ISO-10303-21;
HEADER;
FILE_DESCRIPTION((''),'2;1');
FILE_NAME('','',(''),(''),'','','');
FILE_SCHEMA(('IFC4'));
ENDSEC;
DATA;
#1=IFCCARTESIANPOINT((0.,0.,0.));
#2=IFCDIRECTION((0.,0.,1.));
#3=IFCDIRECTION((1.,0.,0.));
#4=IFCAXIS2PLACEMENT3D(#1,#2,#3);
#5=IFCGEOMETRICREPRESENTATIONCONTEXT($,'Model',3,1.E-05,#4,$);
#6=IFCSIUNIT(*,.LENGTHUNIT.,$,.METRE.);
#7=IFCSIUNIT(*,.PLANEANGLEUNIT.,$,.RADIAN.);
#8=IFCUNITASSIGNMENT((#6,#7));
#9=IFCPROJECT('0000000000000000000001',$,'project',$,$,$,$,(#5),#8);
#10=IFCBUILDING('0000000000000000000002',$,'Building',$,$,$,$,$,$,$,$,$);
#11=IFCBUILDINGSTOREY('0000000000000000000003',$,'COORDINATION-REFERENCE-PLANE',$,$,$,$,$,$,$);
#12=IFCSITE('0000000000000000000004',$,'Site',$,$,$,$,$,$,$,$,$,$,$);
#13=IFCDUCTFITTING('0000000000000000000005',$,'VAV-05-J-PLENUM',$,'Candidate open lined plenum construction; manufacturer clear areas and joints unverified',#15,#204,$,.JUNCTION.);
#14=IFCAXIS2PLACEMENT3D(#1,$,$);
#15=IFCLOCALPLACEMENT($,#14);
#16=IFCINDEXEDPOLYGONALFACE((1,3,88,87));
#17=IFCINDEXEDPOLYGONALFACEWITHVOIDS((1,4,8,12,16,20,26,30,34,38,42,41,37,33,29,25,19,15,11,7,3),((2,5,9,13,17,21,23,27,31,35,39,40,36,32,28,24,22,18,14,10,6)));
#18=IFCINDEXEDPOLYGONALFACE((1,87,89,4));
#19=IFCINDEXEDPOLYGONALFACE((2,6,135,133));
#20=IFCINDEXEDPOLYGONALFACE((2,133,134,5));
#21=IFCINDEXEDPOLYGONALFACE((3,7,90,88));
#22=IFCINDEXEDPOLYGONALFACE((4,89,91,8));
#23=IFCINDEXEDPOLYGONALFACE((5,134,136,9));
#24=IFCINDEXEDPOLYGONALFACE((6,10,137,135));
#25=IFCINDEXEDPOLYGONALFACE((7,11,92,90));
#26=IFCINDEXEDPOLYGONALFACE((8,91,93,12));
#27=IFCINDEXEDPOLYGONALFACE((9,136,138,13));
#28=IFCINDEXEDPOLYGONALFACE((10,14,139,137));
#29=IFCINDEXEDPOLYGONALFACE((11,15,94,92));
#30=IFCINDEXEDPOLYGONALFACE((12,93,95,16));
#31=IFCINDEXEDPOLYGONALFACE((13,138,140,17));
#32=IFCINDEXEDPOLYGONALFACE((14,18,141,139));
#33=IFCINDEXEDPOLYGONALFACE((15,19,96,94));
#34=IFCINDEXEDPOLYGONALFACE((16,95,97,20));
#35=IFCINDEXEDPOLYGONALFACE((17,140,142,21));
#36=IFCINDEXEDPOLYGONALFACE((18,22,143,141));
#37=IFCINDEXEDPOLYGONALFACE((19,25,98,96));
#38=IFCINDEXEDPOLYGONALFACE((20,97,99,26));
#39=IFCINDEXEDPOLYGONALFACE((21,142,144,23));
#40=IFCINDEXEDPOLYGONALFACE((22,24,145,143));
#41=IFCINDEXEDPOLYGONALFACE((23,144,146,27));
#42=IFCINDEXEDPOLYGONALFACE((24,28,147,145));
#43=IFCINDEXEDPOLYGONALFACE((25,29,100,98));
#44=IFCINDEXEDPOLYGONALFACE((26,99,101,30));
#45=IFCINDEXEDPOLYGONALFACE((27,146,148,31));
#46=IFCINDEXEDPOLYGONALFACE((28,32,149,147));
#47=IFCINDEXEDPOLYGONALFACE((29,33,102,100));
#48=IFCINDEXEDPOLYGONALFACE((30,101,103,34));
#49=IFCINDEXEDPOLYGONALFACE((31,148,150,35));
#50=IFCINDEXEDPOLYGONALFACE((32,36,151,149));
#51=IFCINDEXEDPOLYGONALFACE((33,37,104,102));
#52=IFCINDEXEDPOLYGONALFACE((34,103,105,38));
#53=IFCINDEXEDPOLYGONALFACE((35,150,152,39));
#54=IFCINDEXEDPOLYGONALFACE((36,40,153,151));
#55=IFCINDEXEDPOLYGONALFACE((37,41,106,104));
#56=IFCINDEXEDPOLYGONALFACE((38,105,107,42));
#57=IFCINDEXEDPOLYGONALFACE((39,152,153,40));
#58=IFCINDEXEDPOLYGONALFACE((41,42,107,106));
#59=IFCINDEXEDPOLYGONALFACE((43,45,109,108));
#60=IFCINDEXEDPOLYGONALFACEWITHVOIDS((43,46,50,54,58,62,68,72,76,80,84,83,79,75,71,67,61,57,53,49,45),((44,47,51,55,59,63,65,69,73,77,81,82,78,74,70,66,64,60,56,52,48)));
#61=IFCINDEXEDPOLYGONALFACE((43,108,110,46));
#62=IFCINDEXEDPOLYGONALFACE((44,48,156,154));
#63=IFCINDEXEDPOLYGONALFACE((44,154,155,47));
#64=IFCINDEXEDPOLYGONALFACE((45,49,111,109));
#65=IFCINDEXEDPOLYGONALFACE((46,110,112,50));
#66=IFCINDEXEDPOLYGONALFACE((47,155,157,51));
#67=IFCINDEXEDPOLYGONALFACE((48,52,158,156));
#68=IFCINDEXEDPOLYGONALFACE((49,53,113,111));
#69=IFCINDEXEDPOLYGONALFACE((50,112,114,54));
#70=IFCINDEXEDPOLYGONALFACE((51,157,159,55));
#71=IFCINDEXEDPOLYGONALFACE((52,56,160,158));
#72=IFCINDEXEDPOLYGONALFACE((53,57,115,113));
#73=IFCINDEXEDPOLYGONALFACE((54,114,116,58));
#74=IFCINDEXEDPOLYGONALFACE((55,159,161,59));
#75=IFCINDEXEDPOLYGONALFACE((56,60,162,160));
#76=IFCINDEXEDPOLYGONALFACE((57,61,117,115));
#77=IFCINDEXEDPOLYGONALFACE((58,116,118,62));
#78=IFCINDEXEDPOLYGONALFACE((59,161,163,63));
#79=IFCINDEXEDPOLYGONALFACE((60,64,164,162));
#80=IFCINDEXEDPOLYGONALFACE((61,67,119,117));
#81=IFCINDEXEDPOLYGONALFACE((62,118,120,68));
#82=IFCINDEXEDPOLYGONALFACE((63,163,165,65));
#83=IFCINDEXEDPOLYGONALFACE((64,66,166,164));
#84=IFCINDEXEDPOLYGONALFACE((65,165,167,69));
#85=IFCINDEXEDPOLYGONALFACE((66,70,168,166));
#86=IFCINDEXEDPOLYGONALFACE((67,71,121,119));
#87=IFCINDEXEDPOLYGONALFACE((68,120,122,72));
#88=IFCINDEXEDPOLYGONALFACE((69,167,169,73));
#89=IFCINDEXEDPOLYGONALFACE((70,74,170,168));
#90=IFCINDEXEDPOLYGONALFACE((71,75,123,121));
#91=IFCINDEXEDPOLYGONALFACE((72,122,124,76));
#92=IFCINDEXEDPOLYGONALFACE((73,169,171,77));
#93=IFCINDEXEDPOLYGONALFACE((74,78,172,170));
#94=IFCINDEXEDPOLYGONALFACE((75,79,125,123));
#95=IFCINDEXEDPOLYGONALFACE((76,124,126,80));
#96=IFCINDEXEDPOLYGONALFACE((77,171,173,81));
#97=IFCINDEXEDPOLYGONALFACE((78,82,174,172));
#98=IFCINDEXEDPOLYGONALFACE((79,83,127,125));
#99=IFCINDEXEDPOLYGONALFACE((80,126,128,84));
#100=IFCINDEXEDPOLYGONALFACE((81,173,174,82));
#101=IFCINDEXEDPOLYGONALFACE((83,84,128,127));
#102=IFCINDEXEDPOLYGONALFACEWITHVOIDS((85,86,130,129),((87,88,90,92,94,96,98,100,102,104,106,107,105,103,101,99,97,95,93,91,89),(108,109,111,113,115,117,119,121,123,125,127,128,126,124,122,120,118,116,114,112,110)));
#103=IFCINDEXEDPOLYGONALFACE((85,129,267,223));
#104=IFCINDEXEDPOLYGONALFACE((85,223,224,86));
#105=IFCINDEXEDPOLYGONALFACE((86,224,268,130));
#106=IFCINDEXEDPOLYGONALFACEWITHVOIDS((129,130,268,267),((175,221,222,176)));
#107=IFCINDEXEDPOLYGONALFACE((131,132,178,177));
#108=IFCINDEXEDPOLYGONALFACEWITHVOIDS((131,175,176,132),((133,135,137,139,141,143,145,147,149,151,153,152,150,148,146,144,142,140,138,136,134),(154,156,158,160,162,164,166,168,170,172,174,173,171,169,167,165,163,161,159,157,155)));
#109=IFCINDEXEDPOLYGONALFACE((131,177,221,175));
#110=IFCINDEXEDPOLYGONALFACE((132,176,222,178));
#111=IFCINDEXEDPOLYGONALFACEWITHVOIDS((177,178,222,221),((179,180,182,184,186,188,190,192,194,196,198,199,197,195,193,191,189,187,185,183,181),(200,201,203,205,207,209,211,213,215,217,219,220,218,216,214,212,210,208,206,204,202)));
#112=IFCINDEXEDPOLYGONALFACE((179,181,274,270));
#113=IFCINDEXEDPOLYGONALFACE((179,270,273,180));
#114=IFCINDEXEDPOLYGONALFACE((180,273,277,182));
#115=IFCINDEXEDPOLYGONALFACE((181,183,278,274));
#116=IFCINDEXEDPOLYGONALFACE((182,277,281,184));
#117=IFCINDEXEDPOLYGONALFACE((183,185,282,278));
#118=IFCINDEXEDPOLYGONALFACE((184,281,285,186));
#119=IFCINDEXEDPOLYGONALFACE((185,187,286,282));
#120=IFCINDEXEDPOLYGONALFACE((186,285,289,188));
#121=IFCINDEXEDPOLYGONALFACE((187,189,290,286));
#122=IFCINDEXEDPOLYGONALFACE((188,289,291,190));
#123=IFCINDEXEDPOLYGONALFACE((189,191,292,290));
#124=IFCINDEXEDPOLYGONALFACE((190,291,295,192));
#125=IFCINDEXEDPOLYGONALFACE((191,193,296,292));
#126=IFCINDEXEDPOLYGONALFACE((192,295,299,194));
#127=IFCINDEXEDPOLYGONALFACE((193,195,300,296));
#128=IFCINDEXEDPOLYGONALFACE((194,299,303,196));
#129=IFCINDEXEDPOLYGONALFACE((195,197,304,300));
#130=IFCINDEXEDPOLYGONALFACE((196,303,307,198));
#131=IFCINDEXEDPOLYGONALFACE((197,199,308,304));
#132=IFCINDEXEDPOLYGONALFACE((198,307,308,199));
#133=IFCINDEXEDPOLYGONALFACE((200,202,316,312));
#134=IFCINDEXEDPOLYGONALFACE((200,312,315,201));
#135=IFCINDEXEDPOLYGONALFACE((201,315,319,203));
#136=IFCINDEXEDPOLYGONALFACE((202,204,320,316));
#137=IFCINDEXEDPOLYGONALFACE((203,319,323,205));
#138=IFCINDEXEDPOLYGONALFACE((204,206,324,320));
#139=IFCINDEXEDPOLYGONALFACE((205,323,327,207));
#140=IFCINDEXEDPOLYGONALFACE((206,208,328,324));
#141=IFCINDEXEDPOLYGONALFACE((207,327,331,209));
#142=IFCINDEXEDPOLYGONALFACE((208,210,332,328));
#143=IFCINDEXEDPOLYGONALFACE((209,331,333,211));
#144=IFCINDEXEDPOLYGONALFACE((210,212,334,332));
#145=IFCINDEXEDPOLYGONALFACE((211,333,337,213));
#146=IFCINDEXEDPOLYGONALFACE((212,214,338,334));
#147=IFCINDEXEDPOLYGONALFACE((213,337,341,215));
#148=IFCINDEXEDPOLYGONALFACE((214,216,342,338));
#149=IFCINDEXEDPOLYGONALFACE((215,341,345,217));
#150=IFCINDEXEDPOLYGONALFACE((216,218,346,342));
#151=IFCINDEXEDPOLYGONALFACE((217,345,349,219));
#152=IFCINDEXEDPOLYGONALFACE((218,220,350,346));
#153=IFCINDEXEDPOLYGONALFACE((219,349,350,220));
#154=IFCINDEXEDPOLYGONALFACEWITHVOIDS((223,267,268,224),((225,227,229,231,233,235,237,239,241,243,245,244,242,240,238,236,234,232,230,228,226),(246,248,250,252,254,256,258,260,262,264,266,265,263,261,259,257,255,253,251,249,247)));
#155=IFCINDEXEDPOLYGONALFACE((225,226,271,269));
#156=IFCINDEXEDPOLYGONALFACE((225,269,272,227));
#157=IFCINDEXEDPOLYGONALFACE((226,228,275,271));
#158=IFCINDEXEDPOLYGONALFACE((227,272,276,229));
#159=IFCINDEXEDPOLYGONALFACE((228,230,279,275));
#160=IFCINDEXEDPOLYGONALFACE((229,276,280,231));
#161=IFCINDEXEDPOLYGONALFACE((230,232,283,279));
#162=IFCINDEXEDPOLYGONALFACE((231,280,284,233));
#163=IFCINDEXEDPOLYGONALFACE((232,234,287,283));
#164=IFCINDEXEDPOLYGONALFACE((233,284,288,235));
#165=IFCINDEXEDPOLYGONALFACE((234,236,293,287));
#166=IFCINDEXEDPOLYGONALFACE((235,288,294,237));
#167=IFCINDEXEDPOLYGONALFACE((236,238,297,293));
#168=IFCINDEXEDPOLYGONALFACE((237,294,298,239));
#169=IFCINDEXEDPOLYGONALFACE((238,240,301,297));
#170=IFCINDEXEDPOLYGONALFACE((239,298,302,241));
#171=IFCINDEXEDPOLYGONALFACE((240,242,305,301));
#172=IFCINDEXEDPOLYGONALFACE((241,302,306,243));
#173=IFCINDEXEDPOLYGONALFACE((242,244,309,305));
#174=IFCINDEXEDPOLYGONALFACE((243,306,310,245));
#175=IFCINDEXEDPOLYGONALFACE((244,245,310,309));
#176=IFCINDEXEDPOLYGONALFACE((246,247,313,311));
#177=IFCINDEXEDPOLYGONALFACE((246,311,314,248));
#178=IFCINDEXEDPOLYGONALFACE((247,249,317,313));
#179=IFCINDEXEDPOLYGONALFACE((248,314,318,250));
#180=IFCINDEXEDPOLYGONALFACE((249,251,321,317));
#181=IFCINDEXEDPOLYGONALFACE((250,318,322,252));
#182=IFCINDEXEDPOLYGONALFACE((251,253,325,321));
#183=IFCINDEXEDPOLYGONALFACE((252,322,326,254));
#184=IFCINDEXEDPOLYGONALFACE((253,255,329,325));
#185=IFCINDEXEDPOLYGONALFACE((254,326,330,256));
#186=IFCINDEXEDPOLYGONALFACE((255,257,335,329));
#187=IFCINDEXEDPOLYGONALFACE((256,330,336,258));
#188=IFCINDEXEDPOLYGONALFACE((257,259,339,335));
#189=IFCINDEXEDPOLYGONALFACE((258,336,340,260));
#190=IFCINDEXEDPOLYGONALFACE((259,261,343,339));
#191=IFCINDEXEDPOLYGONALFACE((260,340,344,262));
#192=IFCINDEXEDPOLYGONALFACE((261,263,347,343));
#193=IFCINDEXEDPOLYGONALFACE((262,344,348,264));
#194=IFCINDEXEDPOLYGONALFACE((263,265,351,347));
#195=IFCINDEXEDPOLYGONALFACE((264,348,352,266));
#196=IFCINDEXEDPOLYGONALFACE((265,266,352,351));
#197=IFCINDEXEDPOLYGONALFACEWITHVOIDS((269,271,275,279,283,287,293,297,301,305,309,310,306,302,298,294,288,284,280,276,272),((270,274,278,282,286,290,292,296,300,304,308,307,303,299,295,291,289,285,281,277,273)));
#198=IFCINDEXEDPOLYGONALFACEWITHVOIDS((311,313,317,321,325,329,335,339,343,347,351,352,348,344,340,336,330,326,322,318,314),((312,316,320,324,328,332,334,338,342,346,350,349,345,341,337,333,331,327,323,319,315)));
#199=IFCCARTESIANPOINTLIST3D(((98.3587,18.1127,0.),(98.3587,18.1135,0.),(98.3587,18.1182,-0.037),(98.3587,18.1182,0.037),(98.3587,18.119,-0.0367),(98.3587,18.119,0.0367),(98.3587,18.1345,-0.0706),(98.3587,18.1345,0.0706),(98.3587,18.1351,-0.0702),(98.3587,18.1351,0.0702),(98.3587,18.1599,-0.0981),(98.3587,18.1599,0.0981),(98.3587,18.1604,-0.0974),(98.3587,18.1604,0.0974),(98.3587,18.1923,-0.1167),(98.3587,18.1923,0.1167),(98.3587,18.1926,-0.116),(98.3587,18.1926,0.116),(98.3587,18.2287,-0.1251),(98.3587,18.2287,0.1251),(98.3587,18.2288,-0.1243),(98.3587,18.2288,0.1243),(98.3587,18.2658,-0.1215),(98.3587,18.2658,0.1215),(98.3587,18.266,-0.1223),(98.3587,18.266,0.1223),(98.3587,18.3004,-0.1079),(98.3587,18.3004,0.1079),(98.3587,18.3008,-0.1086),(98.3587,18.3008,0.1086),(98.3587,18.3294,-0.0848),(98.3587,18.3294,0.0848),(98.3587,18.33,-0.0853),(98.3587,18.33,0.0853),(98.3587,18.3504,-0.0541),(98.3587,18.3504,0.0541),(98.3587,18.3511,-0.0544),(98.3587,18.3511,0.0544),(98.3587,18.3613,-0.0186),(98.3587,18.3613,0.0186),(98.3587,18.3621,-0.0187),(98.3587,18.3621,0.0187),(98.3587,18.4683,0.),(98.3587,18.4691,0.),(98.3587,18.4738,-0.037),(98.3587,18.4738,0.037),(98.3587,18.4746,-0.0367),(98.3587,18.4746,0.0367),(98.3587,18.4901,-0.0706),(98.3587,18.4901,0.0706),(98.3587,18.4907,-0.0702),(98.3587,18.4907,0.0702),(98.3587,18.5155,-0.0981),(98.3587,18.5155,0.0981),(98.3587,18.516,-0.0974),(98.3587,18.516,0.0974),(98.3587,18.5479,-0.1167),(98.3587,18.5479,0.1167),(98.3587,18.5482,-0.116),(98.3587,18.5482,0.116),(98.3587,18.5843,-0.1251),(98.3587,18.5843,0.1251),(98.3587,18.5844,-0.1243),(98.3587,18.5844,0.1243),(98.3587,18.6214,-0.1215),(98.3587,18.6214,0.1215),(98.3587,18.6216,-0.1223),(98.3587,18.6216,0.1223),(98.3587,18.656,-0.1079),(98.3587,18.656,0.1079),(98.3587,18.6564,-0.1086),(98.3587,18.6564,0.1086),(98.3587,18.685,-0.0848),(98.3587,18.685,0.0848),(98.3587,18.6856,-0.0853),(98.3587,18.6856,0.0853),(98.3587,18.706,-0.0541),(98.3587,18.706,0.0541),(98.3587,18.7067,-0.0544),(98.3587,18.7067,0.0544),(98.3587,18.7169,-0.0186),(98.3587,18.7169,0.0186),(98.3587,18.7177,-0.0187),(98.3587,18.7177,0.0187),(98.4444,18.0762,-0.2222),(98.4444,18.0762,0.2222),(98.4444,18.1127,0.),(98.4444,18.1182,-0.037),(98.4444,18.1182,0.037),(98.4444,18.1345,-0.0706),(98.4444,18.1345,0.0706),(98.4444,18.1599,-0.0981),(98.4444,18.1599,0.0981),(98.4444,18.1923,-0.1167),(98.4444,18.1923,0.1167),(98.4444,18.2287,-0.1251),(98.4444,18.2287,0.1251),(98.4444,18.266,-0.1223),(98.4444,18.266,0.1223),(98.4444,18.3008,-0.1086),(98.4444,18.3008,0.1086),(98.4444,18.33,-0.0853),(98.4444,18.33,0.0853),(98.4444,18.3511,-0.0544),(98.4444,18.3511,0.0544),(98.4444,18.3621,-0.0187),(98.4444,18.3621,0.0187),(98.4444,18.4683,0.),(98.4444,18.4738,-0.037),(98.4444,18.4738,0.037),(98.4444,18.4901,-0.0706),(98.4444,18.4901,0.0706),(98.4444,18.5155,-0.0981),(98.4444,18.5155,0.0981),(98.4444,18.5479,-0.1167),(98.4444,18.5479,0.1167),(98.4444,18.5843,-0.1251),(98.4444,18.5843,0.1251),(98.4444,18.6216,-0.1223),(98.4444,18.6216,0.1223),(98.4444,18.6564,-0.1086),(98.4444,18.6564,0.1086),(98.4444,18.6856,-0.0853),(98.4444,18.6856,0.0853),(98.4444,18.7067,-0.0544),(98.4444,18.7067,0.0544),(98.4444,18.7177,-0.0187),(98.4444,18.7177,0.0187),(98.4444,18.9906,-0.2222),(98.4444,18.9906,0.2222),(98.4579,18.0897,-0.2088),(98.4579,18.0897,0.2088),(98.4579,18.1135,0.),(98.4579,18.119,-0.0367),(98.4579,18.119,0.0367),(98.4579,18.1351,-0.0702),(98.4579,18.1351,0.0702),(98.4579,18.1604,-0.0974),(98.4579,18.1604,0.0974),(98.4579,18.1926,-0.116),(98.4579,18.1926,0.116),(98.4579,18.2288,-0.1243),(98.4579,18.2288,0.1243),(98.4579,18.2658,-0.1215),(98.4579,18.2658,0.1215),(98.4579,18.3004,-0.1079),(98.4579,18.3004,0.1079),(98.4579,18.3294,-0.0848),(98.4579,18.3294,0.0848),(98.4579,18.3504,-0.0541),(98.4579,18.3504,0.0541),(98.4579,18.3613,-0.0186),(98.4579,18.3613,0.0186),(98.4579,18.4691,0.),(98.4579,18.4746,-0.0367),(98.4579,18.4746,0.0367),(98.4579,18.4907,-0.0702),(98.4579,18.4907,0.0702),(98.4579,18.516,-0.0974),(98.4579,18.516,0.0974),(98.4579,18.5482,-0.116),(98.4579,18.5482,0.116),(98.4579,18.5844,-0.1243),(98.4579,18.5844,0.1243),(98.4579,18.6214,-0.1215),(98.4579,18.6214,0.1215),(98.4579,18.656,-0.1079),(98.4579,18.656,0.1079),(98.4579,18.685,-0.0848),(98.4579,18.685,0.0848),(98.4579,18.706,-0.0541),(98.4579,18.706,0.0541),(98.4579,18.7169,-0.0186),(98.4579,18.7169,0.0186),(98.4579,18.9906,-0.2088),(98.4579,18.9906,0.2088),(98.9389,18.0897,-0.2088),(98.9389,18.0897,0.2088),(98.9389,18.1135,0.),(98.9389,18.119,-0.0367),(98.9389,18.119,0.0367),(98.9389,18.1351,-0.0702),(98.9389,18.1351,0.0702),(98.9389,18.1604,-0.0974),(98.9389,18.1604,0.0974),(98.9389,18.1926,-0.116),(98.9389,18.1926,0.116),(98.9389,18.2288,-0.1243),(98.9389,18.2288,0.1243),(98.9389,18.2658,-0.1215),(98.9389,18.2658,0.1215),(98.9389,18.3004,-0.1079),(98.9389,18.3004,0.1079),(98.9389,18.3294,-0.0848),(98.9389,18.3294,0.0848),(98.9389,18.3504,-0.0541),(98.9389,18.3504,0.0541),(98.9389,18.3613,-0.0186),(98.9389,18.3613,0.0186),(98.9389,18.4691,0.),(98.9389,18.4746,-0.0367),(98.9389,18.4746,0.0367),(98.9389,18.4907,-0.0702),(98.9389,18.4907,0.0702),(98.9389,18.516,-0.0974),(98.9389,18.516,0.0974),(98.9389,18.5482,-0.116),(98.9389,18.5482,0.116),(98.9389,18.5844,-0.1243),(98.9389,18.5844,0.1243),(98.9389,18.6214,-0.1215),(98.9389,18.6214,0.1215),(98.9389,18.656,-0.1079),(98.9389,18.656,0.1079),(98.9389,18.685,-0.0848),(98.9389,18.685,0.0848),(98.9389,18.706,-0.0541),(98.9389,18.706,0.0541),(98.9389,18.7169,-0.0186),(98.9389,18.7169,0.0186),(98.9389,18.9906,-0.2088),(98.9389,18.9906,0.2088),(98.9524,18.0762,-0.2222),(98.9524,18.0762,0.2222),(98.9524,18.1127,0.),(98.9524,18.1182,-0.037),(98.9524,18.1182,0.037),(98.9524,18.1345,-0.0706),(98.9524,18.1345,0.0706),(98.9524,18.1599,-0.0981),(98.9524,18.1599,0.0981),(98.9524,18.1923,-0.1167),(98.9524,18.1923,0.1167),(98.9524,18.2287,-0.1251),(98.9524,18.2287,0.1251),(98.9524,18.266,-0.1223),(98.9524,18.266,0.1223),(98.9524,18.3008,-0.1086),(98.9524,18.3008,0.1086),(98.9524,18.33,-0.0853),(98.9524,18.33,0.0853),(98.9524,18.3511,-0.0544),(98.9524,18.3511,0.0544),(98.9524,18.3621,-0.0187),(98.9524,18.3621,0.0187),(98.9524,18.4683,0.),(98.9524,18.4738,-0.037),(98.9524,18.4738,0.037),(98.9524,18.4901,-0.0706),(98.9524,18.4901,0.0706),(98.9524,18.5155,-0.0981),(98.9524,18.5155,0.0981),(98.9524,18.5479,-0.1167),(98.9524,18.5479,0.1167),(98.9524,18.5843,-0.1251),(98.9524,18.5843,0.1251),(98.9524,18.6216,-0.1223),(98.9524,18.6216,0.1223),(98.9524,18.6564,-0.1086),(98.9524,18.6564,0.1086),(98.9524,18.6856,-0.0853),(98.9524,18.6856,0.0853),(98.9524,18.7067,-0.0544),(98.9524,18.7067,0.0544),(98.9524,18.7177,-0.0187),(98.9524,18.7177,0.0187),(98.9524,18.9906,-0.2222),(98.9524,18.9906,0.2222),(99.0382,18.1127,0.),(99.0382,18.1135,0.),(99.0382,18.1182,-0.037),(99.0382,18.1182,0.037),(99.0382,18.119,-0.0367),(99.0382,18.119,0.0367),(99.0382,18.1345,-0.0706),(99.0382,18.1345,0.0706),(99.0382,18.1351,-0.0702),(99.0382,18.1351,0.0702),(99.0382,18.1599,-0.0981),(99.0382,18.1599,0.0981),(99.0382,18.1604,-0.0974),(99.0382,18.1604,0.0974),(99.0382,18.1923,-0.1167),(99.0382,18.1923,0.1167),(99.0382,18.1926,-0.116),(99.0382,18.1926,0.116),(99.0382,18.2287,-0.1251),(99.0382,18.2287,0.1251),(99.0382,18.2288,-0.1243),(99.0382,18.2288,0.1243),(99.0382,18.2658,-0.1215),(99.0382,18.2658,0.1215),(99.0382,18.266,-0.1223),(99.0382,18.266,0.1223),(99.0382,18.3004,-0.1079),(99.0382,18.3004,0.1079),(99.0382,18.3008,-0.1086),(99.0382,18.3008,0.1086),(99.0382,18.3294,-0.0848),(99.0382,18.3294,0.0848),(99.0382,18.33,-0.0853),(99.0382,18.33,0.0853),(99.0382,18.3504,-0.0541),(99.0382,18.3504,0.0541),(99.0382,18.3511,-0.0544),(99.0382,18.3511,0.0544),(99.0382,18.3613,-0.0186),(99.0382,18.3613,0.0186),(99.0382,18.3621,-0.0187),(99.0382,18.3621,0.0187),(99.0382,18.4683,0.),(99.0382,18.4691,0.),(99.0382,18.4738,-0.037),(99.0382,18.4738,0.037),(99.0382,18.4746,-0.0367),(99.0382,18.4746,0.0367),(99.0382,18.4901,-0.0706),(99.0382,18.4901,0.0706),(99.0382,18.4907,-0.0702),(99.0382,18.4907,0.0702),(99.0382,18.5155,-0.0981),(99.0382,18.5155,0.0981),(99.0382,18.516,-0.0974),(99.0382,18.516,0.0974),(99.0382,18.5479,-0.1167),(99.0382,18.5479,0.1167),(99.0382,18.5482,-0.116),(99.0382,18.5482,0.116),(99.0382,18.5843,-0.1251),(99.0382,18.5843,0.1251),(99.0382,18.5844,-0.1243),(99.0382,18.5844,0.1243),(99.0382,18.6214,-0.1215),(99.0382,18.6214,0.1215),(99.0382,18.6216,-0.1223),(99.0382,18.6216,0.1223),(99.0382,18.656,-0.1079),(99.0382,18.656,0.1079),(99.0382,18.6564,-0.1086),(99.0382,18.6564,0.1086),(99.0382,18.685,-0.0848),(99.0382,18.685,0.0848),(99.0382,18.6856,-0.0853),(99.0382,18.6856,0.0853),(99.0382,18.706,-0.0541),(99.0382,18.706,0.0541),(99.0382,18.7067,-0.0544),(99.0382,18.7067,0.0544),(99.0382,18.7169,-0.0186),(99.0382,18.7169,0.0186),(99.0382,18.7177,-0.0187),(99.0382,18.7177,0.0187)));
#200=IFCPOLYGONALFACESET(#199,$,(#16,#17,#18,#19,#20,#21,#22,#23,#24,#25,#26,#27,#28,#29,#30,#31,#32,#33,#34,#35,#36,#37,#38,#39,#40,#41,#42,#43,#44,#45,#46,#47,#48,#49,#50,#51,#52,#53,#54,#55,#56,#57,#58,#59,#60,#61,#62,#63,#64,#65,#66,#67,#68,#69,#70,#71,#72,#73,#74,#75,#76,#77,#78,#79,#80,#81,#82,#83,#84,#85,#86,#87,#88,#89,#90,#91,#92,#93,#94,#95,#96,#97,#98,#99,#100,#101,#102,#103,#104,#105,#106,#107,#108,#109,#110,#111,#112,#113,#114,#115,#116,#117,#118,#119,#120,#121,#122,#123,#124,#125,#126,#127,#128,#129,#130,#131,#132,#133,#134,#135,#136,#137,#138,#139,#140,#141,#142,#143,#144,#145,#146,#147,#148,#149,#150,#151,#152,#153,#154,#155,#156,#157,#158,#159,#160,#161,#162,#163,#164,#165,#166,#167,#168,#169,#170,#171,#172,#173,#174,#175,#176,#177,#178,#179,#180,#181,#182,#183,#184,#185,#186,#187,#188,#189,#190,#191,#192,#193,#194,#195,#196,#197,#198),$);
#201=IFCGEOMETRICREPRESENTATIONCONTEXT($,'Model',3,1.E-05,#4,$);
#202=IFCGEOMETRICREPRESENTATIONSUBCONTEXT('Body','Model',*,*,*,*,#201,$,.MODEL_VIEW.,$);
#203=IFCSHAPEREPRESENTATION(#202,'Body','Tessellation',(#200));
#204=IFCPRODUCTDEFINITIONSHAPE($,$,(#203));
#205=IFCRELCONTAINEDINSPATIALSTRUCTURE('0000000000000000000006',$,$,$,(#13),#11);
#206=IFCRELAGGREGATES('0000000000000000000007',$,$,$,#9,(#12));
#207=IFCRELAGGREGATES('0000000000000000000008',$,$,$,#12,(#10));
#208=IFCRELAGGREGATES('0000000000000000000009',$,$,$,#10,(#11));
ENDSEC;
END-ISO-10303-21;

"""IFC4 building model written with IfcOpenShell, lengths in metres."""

from ifc_helpers import new_model, si_unit, frame, origin_with_axes, place, context, subcontext, project, spatial, rectangle, circle, extrude, boolean, element, save


model = new_model("IFC4")

# Units and contexts
model_context_1 = context("Model", 3, precision=1e-05, world=origin_with_axes())
model_context_2 = context("Model", 3, precision=1e-05, world=origin_with_axes())
body_context_1 = subcontext(model_context_2, "Body", "Model", "MODEL_VIEW")
ifc_project = project(units=[si_unit("LENGTHUNIT", "METRE"), si_unit("PLANEANGLEUNIT", "RADIAN")], contexts=[model_context_1])

# Site, building, storey
site = spatial("IfcSite", under=ifc_project, Name="Site")
building = spatial("IfcBuilding", under=site, Name="Building")
storey = spatial("IfcBuildingStorey", under=building, Name="COORDINATION-REFERENCE-PLANE")

# Duct fitting
duct_fitting_1_placement = place(None, frame((98.4444, 18.0762, -0.2223), z_axis=(0.0, 0.0, 1.0), x_axis=(1.0, 0.0, 0.0)))
solid_1 = boolean("UNION", boolean("UNION", boolean("UNION", boolean("UNION", extrude(rectangle(XDim=0.481, YDim=0.4175), frame((0.254, 0.9244, 0.2223), z_axis=(0.0, -1.0, 0.0), x_axis=(1.0, 0.0, 0.0)), (0.0, 0.0, 1.0), 0.9109), extrude(circle(Radius=0.1246), frame((0.0235, 0.5175, 0.2223), z_axis=(-1.0, 0.0, 0.0), x_axis=(0.0, -1.0, 0.0)), (0.0, 0.0, 1.0), 0.1192)), extrude(circle(Radius=0.1246), frame((0.4845, 0.5175, 0.2223), z_axis=(1.0, 0.0, 0.0), x_axis=(0.0, -1.0, 0.0)), (0.0, 0.0, 1.0), 0.1192)), extrude(circle(Radius=0.1246), frame((0.0235, 0.1619, 0.2223), z_axis=(-1.0, 0.0, 0.0), x_axis=(0.0, -1.0, 0.0)), (0.0, 0.0, 1.0), 0.1192)), extrude(circle(Radius=0.1246), frame((0.4845, 0.1619, 0.2223), z_axis=(1.0, 0.0, 0.0), x_axis=(0.0, -1.0, 0.0)), (0.0, 0.0, 1.0), 0.1192))
element("IfcDuctFitting", 1, at=duct_fitting_1_placement, inside=storey, Name="VAV-05-J-PLENUM", ObjectType="Candidate open lined plenum construction; manufacturer clear areas and joints unverified", PredefinedType="JUNCTION", context=body_context_1, shape_type="CSG", body=[
    boolean("DIFFERENCE", boolean("UNION", boolean("UNION", boolean("UNION", boolean("UNION", extrude(rectangle(XDim=0.508, YDim=0.4445), frame((0.254, 0.9144, 0.2223), z_axis=(0.0, -1.0, 0.0), x_axis=(1.0, 0.0, 0.0)), (0.0, 0.0, 1.0), 0.9144), extrude(circle(Radius=0.1254), frame((0.0235, 0.5175, 0.2223), z_axis=(-1.0, 0.0, 0.0), x_axis=(0.0, -1.0, 0.0)), (0.0, 0.0, 1.0), 0.1092)), extrude(circle(Radius=0.1254), frame((0.4845, 0.5175, 0.2223), z_axis=(1.0, 0.0, 0.0), x_axis=(0.0, -1.0, 0.0)), (0.0, 0.0, 1.0), 0.1092)), extrude(circle(Radius=0.1254), frame((0.0235, 0.1619, 0.2223), z_axis=(-1.0, 0.0, 0.0), x_axis=(0.0, -1.0, 0.0)), (0.0, 0.0, 1.0), 0.1092)), extrude(circle(Radius=0.1254), frame((0.4845, 0.1619, 0.2223), z_axis=(1.0, 0.0, 0.0), x_axis=(0.0, -1.0, 0.0)), (0.0, 0.0, 1.0), 0.1092)), solid_1),
])

save(model, "model.ifc")
